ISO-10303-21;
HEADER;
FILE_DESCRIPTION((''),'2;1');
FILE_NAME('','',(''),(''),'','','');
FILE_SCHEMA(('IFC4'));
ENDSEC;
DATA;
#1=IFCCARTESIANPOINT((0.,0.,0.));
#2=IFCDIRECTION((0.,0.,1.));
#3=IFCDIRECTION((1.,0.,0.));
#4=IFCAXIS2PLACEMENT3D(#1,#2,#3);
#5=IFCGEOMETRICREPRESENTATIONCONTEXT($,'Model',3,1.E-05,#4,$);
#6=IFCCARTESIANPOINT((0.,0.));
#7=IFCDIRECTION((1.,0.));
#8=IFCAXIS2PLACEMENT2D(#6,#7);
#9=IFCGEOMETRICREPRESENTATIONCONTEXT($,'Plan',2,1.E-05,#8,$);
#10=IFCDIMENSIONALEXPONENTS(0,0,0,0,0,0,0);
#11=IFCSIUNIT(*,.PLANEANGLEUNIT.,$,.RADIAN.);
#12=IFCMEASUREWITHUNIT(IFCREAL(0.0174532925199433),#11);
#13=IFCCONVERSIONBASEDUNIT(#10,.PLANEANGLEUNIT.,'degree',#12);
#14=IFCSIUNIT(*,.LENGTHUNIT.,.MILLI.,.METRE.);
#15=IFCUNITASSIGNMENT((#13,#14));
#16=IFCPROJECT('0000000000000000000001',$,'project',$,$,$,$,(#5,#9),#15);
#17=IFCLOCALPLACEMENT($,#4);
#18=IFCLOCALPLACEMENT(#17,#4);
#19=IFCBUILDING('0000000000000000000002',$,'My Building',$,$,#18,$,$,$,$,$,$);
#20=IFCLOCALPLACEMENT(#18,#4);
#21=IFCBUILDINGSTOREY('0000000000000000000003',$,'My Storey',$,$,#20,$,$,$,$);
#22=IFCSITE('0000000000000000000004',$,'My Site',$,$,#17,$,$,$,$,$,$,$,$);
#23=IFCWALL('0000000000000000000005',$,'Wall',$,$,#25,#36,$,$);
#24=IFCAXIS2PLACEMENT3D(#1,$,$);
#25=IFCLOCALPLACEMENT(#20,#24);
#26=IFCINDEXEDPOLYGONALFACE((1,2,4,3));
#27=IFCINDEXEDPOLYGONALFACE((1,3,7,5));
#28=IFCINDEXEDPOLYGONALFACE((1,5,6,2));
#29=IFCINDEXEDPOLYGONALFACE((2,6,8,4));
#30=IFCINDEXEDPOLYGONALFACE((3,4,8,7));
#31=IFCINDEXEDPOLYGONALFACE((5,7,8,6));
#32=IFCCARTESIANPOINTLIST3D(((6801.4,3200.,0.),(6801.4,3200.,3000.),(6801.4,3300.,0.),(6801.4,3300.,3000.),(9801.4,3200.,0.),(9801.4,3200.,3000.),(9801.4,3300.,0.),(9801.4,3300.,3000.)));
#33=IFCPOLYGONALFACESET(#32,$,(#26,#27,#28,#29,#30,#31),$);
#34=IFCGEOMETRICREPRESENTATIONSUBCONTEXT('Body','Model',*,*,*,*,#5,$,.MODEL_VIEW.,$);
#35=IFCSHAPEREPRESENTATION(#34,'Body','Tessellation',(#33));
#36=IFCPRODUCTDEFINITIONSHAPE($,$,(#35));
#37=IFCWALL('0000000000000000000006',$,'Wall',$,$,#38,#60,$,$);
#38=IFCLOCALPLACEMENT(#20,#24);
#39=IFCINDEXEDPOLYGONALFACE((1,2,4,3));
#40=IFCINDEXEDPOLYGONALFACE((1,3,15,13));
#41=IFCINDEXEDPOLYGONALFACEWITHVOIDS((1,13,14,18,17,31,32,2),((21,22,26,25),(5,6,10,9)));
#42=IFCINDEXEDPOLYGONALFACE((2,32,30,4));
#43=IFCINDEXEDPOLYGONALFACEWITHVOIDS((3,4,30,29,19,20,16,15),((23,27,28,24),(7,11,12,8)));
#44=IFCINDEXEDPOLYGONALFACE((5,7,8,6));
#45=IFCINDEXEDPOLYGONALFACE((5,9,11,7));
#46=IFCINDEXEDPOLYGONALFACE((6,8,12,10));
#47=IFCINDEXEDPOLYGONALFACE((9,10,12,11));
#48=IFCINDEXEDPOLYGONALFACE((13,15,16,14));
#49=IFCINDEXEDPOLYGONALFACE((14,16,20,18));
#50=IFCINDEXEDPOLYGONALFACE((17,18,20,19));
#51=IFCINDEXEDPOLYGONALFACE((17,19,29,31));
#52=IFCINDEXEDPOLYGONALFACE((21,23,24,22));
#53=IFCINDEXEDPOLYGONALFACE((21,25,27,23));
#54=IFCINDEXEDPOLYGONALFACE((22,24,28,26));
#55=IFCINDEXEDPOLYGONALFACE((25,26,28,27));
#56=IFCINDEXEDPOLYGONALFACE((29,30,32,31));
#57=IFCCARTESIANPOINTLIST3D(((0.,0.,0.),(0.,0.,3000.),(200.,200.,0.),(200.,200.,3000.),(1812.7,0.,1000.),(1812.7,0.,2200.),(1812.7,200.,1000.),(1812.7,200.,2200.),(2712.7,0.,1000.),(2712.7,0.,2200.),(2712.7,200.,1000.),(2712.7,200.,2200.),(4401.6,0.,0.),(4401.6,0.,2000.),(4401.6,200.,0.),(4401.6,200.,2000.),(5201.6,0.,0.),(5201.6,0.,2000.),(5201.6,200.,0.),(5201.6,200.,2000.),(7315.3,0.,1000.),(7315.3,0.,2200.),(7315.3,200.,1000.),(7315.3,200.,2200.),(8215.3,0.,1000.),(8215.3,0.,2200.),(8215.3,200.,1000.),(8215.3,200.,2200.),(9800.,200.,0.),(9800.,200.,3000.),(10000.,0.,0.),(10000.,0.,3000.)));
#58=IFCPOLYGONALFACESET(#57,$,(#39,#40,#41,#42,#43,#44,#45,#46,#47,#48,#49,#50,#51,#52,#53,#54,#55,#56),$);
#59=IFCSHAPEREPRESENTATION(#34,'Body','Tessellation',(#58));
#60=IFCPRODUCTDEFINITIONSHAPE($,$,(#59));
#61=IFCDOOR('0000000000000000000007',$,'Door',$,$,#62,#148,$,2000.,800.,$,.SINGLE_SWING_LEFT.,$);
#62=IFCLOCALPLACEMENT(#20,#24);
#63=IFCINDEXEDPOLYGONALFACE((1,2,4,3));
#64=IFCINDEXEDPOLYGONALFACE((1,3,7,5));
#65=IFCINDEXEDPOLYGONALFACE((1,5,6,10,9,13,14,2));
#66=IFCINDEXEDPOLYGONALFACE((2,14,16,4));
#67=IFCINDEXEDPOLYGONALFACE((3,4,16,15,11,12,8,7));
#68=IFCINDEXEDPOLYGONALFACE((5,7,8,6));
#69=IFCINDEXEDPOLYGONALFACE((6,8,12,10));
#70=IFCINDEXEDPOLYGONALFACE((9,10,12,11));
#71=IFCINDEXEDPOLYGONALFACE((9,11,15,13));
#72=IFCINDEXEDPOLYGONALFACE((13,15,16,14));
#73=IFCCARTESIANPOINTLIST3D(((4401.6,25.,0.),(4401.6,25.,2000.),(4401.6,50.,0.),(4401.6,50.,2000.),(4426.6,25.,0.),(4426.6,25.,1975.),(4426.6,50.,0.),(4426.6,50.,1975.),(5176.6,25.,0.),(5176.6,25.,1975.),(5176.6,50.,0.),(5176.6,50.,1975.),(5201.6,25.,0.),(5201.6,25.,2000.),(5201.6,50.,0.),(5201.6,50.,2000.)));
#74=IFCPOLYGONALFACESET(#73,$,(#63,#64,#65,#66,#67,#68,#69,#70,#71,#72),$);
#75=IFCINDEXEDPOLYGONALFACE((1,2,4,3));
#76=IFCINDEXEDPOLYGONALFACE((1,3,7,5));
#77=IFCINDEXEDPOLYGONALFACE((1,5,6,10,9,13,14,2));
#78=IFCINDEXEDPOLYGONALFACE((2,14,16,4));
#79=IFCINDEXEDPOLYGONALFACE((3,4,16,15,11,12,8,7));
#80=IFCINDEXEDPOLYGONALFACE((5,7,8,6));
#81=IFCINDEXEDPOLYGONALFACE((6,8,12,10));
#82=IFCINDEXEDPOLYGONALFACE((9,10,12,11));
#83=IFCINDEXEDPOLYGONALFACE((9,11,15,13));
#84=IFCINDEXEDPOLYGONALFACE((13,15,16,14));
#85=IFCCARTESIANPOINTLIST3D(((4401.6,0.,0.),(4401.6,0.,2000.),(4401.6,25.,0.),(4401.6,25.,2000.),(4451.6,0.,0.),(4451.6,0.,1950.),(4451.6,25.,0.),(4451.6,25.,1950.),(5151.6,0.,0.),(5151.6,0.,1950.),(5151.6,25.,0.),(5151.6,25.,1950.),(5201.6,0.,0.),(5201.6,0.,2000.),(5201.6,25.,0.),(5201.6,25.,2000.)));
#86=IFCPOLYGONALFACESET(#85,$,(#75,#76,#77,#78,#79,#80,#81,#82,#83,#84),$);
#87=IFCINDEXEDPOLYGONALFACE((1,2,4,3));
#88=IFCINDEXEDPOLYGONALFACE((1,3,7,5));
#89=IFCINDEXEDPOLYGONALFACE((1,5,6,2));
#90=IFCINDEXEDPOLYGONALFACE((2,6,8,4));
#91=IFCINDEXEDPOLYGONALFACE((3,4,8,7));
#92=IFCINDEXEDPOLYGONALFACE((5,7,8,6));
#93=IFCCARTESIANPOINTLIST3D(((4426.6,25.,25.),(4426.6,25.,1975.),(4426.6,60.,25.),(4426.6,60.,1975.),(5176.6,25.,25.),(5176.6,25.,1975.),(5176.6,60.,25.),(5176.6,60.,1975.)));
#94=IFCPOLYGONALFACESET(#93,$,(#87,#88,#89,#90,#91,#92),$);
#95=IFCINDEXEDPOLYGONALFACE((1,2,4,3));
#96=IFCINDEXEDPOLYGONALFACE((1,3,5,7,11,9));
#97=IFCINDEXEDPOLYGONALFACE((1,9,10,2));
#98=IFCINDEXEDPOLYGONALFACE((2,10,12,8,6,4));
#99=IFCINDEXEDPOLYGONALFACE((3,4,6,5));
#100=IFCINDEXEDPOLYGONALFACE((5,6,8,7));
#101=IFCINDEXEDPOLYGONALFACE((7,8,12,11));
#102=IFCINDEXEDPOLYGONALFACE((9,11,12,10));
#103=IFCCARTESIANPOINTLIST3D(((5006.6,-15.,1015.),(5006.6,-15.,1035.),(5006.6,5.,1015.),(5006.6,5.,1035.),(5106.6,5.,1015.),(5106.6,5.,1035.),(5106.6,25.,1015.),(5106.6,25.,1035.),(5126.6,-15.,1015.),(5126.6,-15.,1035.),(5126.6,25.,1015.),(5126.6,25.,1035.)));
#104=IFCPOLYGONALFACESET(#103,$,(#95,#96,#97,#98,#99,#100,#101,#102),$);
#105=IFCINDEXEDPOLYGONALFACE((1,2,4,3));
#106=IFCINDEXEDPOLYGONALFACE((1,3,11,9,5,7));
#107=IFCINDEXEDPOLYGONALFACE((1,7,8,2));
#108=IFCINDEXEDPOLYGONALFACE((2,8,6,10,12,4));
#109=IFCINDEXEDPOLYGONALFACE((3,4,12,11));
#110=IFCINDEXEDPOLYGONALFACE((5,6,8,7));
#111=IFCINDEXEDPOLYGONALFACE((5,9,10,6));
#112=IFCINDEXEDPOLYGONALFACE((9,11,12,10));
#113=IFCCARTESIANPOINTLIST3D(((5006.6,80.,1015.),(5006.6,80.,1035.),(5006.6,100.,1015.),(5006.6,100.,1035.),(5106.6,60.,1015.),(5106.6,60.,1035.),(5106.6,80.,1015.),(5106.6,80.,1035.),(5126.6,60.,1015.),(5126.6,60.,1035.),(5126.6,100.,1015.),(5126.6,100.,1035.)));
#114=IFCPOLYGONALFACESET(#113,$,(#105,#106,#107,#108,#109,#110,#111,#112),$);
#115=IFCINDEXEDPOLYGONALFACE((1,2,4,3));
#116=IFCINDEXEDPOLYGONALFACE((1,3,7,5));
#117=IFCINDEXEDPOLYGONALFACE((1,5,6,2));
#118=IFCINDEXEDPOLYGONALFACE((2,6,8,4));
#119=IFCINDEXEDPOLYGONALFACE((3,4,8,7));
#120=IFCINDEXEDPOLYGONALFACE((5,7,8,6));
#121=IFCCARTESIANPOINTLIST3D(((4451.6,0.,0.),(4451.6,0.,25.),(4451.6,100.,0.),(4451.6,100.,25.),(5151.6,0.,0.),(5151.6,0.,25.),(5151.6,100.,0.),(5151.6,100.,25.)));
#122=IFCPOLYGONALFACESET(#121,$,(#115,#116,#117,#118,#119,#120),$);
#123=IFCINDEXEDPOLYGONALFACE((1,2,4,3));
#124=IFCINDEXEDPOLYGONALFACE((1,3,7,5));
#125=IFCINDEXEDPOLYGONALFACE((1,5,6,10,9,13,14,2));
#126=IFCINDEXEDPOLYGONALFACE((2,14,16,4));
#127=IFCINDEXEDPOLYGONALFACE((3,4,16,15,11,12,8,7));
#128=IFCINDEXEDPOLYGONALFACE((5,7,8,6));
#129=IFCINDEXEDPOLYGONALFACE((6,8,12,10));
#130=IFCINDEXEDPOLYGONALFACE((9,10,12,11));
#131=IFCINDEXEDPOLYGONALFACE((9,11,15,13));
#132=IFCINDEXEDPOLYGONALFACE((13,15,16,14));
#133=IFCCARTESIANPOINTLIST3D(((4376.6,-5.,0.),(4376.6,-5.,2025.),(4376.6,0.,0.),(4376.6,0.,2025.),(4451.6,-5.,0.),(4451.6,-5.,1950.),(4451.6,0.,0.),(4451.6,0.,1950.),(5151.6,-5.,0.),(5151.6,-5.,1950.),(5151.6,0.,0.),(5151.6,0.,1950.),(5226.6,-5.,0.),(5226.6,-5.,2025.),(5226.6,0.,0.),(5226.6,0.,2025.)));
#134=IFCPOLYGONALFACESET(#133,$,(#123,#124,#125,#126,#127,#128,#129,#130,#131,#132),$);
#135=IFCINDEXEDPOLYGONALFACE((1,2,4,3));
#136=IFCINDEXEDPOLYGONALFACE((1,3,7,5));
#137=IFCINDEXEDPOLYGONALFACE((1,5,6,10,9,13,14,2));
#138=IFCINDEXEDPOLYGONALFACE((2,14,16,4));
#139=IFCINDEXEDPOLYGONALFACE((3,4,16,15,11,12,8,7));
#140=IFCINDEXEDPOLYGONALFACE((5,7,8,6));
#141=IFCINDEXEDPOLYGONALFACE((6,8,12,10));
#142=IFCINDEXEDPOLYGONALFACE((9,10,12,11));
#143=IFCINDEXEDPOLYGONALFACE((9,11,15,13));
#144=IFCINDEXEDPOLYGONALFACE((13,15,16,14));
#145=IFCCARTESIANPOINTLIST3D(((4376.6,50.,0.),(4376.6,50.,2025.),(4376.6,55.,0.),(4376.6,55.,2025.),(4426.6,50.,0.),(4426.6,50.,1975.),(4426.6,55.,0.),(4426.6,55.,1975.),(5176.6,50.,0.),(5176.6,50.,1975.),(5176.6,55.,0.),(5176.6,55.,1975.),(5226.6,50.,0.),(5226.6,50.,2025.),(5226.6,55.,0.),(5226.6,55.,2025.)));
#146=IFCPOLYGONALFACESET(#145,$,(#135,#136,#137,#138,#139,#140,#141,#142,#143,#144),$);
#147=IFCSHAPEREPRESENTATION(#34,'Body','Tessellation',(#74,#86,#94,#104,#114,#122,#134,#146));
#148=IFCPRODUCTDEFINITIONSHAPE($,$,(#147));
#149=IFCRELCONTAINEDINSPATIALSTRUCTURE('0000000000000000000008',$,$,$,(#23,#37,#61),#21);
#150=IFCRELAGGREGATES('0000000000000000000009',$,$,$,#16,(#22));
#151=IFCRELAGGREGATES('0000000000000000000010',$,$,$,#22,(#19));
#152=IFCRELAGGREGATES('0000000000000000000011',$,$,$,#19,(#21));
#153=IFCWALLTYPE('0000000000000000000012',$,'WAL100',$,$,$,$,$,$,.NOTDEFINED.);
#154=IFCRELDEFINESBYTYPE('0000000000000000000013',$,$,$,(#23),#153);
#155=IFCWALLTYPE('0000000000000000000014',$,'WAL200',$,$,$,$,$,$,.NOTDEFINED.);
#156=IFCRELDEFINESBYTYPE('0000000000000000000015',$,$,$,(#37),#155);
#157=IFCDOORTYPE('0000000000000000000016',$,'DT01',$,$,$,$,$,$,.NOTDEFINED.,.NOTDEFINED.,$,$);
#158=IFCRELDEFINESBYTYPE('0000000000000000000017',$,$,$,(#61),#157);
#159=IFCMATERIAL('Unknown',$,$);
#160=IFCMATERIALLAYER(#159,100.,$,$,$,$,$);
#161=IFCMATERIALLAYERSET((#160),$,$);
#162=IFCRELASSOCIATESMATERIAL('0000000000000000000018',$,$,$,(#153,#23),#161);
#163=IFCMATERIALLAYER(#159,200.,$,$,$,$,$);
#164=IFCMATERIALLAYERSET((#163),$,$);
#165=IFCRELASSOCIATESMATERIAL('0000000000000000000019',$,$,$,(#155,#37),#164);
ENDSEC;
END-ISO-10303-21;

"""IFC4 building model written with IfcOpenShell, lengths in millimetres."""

from ifc_helpers import new_model, entity, si_unit, converted_unit, frame, origin_with_axes, origin_2d_with_axis, place, context, subcontext, project, spatial, line, indexed_curve, outline, extrude, clip, halfspace, shape, source, transform, mapped, material, layer, layer_set, layer_usage, type_object, type_shapes, element, fill, save


model = new_model("IFC4")

# Units and contexts
model_context = context("Model", 3, precision=1e-05, world=origin_with_axes())
plan_context = context("Plan", 2, precision=1e-05, world=origin_2d_with_axis())
body_context_1 = subcontext(model_context, "Body", "Model", "MODEL_VIEW")
body_context_2 = subcontext(plan_context, "Body", "Plan", "PLAN_VIEW")
ifc_project = project(units=[converted_unit("PLANEANGLEUNIT", "degree", entity("IfcReal", 0.0174532925199433), si_unit("PLANEANGLEUNIT", "RADIAN"), dimensions=[0, 0, 0, 0, 0, 0, 0]), si_unit("LENGTHUNIT", "METRE", prefix="MILLI")], contexts=[model_context, plan_context])

# Site, building, storey
site_placement = place(None, origin_with_axes())
site = spatial("IfcSite", under=ifc_project, at=site_placement, Name="My Site")
building_placement = place(site_placement, origin_with_axes())
building = spatial("IfcBuilding", under=site, at=building_placement, Name="My Building")
storey_placement = place(building_placement, origin_with_axes())
storey = spatial("IfcBuildingStorey", under=building, at=storey_placement, Name="My Storey")

# Wall
ifc_material = material(Name="Unknown")
ifc_layer_1 = layer(ifc_material, 100.0)
ifc_layer_set_1 = layer_set([ifc_layer_1])
ifc_layer_usage_1 = layer_usage(ifc_layer_set_1, "AXIS2", "POSITIVE", 0.0)
wall_type_1 = type_object("IfcWallType", Name="WAL100", PredefinedType="NOTDEFINED", material=ifc_layer_set_1)
wall_1_placement = place(storey_placement, frame((9801.4, 3300.0, 0.0), z_axis=(0.0, 0.0, 1.0), x_axis=(-1.0, 0.0, 0.0)))
element("IfcWall", 1, at=wall_1_placement, inside=storey, type_object=wall_type_1, material=ifc_layer_usage_1, Name="Wall", context=body_context_1, shape_type="SweptSolid", body=[
    extrude(outline(indexed_curve([(0.0, 0.0), (0.0, 100.0), (3000.0, 100.0), (3000.0, 0.0), (0.0, 0.0)], self_intersect=False)), origin_with_axes(), (0.0, 0.0, 1.0), 3000.0),
])

# Shared definitions
shared_shape_1 = source(origin_with_axes(), body_context_1, "Body", "SolidModel", [
    extrude(outline(indexed_curve([(0.0, 0.0), (800.0, 0.0), (800.0, 2000.0), (0.0, 2000.0)], segments=[line(1, 2, 3, 4, 1)])), frame((0.0, -600.0, 0.0), z_axis=(0.0, -1.0, 0.0), x_axis=(1.0, 0.0, 0.0)), (0.0, 0.0, -1.0), 1200.0),
])
door_type = type_object("IfcDoorType", Name="DT01", OperationType="NOTDEFINED", PredefinedType="NOTDEFINED")
shared_shape_2 = source(origin_with_axes(), body_context_1, "Body", "SolidModel", [
    extrude(outline(indexed_curve([(0.0, 0.0), (0.0, 2000.0), (800.0, 2000.0), (800.0, 0.0), (775.0, 0.0), (775.0, 1975.0), (25.0, 1975.0), (25.0, 0.0)], segments=[line(1, 2, 3, 4, 5, 6, 7, 8, 1)])), frame((0.0, 25.0, 0.0), z_axis=(0.0, -1.0, 0.0), x_axis=(1.0, 0.0, 0.0)), (0.0, 0.0, -1.0), 25.0),
    extrude(outline(indexed_curve([(0.0, 0.0), (0.0, 2000.0), (800.0, 2000.0), (800.0, 0.0), (750.0, 0.0), (750.0, 1950.0), (50.0, 1950.0), (50.0, 0.0)], segments=[line(1, 2, 3, 4, 5, 6, 7, 8, 1)])), frame((0.0, 0.0, 0.0), z_axis=(0.0, -1.0, 0.0), x_axis=(1.0, 0.0, 0.0)), (0.0, 0.0, -1.0), 25.0),
    extrude(outline(indexed_curve([(0.0, 0.0), (750.0, 0.0), (750.0, 35.0), (0.0, 35.0)], segments=[line(1, 2, 3, 4, 1)])), frame((25.0, 25.0, 25.0), z_axis=(0.0, 0.0, 1.0), x_axis=(1.0, 0.0, 0.0)), (0.0, 0.0, 1.0), 1950.0),
    extrude(outline(indexed_curve([(0.0, 0.0), (0.0, -40.0), (-120.0, -40.0), (-120.0, -20.0), (-20.0, -20.0), (-20.0, 0.0)], segments=[line(1, 2, 3, 4, 5, 6, 1)])), frame((725.0, 25.0, 1015.0), z_axis=(0.0, 0.0, 1.0), x_axis=(1.0, 0.0, 0.0)), (0.0, 0.0, 1.0), 20.0),
    extrude(outline(indexed_curve([(0.0, 0.0), (0.0, 40.0), (-120.0, 40.0), (-120.0, 20.0), (-20.0, 20.0), (-20.0, 0.0)], segments=[line(1, 2, 3, 4, 5, 6, 1)])), frame((725.0, 60.0, 1015.0), z_axis=(0.0, 0.0, 1.0), x_axis=(1.0, 0.0, 0.0)), (0.0, 0.0, 1.0), 20.0),
    extrude(outline(indexed_curve([(0.0, 0.0), (700.0, 0.0), (700.0, 100.0), (0.0, 100.0)], segments=[line(1, 2, 3, 4, 1)])), frame((50.0, 0.0, 0.0), z_axis=(0.0, 0.0, 1.0), x_axis=(1.0, 0.0, 0.0)), (0.0, 0.0, 1.0), 25.0),
    extrude(outline(indexed_curve([(0.0, 0.0), (0.0, 2025.0), (850.0, 2025.0), (850.0, 0.0), (775.0, 0.0), (775.0, 1950.0), (75.0, 1950.0), (75.0, 0.0)], segments=[line(1, 2, 3, 4, 5, 6, 7, 8, 1)])), frame((-25.0, -5.0, 0.0), z_axis=(0.0, -1.0, 0.0), x_axis=(1.0, 0.0, 0.0)), (0.0, 0.0, -1.0), 5.0),
    extrude(outline(indexed_curve([(0.0, 0.0), (0.0, 2025.0), (850.0, 2025.0), (850.0, 0.0), (800.0, 0.0), (800.0, 1975.0), (50.0, 1975.0), (50.0, 0.0)], segments=[line(1, 2, 3, 4, 5, 6, 7, 8, 1)])), frame((-25.0, 50.0, 0.0), z_axis=(0.0, -1.0, 0.0), x_axis=(1.0, 0.0, 0.0)), (0.0, 0.0, -1.0), 5.0),
])
shared_shape_3 = source(origin_with_axes(), body_context_2, "Body", "Curve2D", [
    entity("IfcIndexedPolyCurve", entity("IfcCartesianPointList2D", [[0.0, 0.0], [0.0, 50.0], [25.0, 50.0], [25.0, 25.0], [50.0, 25.0], [50.0, 0.0]]), [entity("IfcLineIndex", [1, 2, 3, 4, 5, 6, 1])]),
    entity("IfcIndexedPolyCurve", entity("IfcCartesianPointList2D", [[800.0, 0.0], [800.0, 50.0], [775.0, 50.0], [775.0, 25.0], [750.0, 25.0], [750.0, 0.0]]), [entity("IfcLineIndex", [1, 2, 3, 4, 5, 6, 1])]),
    entity("IfcTrimmedCurve", entity("IfcEllipse", entity("IfcAxis2Placement2D", entity("IfcCartesianPoint", [60.0, 50.0]), entity("IfcDirection", [1.0, 0.0])), 715.0, 750.0), [entity("IfcCartesianPoint", [775.0, 50.0])], [entity("IfcCartesianPoint", [60.0, 800.0])], True, "CARTESIAN"),
    entity("IfcIndexedPolyCurve", entity("IfcCartesianPointList2D", [[25.0, 50.0], [60.0, 50.0], [60.0, 800.0], [25.0, 800.0]]), [entity("IfcLineIndex", [1, 2, 3, 4, 1])]),
])
type_shapes(door_type, [shared_shape_2, shared_shape_3])

# Wall, openings, door
ifc_layer_2 = layer(ifc_material, 200.0)
ifc_layer_set_2 = layer_set([ifc_layer_2])
ifc_layer_usage_2 = layer_usage(ifc_layer_set_2, "AXIS2", "POSITIVE", 0.0)
wall_type_2 = type_object("IfcWallType", Name="WAL200", PredefinedType="NOTDEFINED", material=ifc_layer_set_2)
wall_2_placement = place(storey_placement, origin_with_axes())
wall_2 = element("IfcWall", 2, at=wall_2_placement, inside=storey, type_object=wall_type_2, material=ifc_layer_usage_2, Name="Wall", context=body_context_1, shape_type="Clipping", body=[
    clip(clip(extrude(outline(indexed_curve([(0.0, 0.0), (0.0, 200.0), (10000.0, 200.0), (10000.0, 0.0), (0.0, 0.0)], self_intersect=False)), origin_with_axes(), (0.0, 0.0, 1.0), 3000.0), halfspace(frame((10000.0, 0.0, 0.0), z_axis=(0.707107, 0.707106, 0.0), x_axis=(0.707106, -0.707107, 0.0)), False)), halfspace(frame((0.0, 0.0, 0.0), z_axis=(-0.707107, 0.707107, 0.0), x_axis=(0.707107, 0.707107, 0.0)), False)),
])
opening_1_placement = place(wall_2_placement, frame((4401.6, 0.0, 0.0), z_axis=(0.0, 0.0, 1.0), x_axis=(1.0, 0.0, 0.0)))
opening_1 = element("IfcOpeningElement", 3, at=opening_1_placement, cuts=wall_2, PredefinedType="OPENING", context=body_context_1, shape_type="MappedRepresentation", body=[
    mapped(shared_shape_1, transform((0.0, 0.0, 0.0), x_axis=(1.0, 0.0, 0.0), y_axis=(0.0, 1.0, 0.0), z_axis=(0.0, 0.0, 1.0), scale=1.0)),
])
shared_shape_4 = source(origin_with_axes(), body_context_1, "Body", "SolidModel", [
    extrude(outline(indexed_curve([(0.0, 0.0), (900.0, 0.0), (900.0, 1200.0), (0.0, 1200.0)], segments=[line(1, 2, 3, 4, 1)])), frame((0.0, -600.0, 0.0), z_axis=(0.0, -1.0, 0.0), x_axis=(1.0, 0.0, 0.0)), (0.0, 0.0, -1.0), 1200.0),
])
opening_2_placement = place(wall_2_placement, frame((1812.7, 0.0, 1000.0), z_axis=(0.0, 0.0, 1.0), x_axis=(1.0, 0.0, 0.0)))
element("IfcOpeningElement", 4, at=opening_2_placement, cuts=wall_2, PredefinedType="OPENING", context=body_context_1, shape_type="MappedRepresentation", body=[
    mapped(shared_shape_4, transform((0.0, 0.0, 0.0), x_axis=(1.0, 0.0, 0.0), y_axis=(0.0, 1.0, 0.0), z_axis=(0.0, 0.0, 1.0), scale=1.0)),
])
opening_3_placement = place(wall_2_placement, frame((7315.3, 0.0, 1000.0), z_axis=(0.0, 0.0, 1.0), x_axis=(1.0, 0.0, 0.0)))
element("IfcOpeningElement", 5, at=opening_3_placement, cuts=wall_2, PredefinedType="OPENING", context=body_context_1, shape_type="MappedRepresentation", body=[
    mapped(shared_shape_4, transform((0.0, 0.0, 0.0), x_axis=(1.0, 0.0, 0.0), y_axis=(0.0, 1.0, 0.0), z_axis=(0.0, 0.0, 1.0), scale=1.0)),
])
door_1_placement = place(opening_1_placement, origin_with_axes())
door_1 = element("IfcDoor", 6, at=door_1_placement, inside=storey, type_object=door_type, Name="Door", OperationType="SINGLE_SWING_LEFT", OverallHeight=2000.0, OverallWidth=800.0, shapes=[
    shape(body_context_1, "Body", "MappedRepresentation", [mapped(shared_shape_2, transform((0.0, 0.0, 0.0), x_axis=(1.0, 0.0, 0.0), y_axis=(0.0, 1.0, 0.0), z_axis=(0.0, 0.0, 1.0), scale=1.0))]),
    shape(body_context_2, "Body", "MappedRepresentation", [mapped(shared_shape_3, transform((0.0, 0.0, 0.0), x_axis=(1.0, 0.0, 0.0), y_axis=(0.0, 1.0, 0.0), z_axis=(0.0, 0.0, 1.0), scale=1.0))]),
])
fill(opening_1, door_1)

save(model, "model.ifc")
